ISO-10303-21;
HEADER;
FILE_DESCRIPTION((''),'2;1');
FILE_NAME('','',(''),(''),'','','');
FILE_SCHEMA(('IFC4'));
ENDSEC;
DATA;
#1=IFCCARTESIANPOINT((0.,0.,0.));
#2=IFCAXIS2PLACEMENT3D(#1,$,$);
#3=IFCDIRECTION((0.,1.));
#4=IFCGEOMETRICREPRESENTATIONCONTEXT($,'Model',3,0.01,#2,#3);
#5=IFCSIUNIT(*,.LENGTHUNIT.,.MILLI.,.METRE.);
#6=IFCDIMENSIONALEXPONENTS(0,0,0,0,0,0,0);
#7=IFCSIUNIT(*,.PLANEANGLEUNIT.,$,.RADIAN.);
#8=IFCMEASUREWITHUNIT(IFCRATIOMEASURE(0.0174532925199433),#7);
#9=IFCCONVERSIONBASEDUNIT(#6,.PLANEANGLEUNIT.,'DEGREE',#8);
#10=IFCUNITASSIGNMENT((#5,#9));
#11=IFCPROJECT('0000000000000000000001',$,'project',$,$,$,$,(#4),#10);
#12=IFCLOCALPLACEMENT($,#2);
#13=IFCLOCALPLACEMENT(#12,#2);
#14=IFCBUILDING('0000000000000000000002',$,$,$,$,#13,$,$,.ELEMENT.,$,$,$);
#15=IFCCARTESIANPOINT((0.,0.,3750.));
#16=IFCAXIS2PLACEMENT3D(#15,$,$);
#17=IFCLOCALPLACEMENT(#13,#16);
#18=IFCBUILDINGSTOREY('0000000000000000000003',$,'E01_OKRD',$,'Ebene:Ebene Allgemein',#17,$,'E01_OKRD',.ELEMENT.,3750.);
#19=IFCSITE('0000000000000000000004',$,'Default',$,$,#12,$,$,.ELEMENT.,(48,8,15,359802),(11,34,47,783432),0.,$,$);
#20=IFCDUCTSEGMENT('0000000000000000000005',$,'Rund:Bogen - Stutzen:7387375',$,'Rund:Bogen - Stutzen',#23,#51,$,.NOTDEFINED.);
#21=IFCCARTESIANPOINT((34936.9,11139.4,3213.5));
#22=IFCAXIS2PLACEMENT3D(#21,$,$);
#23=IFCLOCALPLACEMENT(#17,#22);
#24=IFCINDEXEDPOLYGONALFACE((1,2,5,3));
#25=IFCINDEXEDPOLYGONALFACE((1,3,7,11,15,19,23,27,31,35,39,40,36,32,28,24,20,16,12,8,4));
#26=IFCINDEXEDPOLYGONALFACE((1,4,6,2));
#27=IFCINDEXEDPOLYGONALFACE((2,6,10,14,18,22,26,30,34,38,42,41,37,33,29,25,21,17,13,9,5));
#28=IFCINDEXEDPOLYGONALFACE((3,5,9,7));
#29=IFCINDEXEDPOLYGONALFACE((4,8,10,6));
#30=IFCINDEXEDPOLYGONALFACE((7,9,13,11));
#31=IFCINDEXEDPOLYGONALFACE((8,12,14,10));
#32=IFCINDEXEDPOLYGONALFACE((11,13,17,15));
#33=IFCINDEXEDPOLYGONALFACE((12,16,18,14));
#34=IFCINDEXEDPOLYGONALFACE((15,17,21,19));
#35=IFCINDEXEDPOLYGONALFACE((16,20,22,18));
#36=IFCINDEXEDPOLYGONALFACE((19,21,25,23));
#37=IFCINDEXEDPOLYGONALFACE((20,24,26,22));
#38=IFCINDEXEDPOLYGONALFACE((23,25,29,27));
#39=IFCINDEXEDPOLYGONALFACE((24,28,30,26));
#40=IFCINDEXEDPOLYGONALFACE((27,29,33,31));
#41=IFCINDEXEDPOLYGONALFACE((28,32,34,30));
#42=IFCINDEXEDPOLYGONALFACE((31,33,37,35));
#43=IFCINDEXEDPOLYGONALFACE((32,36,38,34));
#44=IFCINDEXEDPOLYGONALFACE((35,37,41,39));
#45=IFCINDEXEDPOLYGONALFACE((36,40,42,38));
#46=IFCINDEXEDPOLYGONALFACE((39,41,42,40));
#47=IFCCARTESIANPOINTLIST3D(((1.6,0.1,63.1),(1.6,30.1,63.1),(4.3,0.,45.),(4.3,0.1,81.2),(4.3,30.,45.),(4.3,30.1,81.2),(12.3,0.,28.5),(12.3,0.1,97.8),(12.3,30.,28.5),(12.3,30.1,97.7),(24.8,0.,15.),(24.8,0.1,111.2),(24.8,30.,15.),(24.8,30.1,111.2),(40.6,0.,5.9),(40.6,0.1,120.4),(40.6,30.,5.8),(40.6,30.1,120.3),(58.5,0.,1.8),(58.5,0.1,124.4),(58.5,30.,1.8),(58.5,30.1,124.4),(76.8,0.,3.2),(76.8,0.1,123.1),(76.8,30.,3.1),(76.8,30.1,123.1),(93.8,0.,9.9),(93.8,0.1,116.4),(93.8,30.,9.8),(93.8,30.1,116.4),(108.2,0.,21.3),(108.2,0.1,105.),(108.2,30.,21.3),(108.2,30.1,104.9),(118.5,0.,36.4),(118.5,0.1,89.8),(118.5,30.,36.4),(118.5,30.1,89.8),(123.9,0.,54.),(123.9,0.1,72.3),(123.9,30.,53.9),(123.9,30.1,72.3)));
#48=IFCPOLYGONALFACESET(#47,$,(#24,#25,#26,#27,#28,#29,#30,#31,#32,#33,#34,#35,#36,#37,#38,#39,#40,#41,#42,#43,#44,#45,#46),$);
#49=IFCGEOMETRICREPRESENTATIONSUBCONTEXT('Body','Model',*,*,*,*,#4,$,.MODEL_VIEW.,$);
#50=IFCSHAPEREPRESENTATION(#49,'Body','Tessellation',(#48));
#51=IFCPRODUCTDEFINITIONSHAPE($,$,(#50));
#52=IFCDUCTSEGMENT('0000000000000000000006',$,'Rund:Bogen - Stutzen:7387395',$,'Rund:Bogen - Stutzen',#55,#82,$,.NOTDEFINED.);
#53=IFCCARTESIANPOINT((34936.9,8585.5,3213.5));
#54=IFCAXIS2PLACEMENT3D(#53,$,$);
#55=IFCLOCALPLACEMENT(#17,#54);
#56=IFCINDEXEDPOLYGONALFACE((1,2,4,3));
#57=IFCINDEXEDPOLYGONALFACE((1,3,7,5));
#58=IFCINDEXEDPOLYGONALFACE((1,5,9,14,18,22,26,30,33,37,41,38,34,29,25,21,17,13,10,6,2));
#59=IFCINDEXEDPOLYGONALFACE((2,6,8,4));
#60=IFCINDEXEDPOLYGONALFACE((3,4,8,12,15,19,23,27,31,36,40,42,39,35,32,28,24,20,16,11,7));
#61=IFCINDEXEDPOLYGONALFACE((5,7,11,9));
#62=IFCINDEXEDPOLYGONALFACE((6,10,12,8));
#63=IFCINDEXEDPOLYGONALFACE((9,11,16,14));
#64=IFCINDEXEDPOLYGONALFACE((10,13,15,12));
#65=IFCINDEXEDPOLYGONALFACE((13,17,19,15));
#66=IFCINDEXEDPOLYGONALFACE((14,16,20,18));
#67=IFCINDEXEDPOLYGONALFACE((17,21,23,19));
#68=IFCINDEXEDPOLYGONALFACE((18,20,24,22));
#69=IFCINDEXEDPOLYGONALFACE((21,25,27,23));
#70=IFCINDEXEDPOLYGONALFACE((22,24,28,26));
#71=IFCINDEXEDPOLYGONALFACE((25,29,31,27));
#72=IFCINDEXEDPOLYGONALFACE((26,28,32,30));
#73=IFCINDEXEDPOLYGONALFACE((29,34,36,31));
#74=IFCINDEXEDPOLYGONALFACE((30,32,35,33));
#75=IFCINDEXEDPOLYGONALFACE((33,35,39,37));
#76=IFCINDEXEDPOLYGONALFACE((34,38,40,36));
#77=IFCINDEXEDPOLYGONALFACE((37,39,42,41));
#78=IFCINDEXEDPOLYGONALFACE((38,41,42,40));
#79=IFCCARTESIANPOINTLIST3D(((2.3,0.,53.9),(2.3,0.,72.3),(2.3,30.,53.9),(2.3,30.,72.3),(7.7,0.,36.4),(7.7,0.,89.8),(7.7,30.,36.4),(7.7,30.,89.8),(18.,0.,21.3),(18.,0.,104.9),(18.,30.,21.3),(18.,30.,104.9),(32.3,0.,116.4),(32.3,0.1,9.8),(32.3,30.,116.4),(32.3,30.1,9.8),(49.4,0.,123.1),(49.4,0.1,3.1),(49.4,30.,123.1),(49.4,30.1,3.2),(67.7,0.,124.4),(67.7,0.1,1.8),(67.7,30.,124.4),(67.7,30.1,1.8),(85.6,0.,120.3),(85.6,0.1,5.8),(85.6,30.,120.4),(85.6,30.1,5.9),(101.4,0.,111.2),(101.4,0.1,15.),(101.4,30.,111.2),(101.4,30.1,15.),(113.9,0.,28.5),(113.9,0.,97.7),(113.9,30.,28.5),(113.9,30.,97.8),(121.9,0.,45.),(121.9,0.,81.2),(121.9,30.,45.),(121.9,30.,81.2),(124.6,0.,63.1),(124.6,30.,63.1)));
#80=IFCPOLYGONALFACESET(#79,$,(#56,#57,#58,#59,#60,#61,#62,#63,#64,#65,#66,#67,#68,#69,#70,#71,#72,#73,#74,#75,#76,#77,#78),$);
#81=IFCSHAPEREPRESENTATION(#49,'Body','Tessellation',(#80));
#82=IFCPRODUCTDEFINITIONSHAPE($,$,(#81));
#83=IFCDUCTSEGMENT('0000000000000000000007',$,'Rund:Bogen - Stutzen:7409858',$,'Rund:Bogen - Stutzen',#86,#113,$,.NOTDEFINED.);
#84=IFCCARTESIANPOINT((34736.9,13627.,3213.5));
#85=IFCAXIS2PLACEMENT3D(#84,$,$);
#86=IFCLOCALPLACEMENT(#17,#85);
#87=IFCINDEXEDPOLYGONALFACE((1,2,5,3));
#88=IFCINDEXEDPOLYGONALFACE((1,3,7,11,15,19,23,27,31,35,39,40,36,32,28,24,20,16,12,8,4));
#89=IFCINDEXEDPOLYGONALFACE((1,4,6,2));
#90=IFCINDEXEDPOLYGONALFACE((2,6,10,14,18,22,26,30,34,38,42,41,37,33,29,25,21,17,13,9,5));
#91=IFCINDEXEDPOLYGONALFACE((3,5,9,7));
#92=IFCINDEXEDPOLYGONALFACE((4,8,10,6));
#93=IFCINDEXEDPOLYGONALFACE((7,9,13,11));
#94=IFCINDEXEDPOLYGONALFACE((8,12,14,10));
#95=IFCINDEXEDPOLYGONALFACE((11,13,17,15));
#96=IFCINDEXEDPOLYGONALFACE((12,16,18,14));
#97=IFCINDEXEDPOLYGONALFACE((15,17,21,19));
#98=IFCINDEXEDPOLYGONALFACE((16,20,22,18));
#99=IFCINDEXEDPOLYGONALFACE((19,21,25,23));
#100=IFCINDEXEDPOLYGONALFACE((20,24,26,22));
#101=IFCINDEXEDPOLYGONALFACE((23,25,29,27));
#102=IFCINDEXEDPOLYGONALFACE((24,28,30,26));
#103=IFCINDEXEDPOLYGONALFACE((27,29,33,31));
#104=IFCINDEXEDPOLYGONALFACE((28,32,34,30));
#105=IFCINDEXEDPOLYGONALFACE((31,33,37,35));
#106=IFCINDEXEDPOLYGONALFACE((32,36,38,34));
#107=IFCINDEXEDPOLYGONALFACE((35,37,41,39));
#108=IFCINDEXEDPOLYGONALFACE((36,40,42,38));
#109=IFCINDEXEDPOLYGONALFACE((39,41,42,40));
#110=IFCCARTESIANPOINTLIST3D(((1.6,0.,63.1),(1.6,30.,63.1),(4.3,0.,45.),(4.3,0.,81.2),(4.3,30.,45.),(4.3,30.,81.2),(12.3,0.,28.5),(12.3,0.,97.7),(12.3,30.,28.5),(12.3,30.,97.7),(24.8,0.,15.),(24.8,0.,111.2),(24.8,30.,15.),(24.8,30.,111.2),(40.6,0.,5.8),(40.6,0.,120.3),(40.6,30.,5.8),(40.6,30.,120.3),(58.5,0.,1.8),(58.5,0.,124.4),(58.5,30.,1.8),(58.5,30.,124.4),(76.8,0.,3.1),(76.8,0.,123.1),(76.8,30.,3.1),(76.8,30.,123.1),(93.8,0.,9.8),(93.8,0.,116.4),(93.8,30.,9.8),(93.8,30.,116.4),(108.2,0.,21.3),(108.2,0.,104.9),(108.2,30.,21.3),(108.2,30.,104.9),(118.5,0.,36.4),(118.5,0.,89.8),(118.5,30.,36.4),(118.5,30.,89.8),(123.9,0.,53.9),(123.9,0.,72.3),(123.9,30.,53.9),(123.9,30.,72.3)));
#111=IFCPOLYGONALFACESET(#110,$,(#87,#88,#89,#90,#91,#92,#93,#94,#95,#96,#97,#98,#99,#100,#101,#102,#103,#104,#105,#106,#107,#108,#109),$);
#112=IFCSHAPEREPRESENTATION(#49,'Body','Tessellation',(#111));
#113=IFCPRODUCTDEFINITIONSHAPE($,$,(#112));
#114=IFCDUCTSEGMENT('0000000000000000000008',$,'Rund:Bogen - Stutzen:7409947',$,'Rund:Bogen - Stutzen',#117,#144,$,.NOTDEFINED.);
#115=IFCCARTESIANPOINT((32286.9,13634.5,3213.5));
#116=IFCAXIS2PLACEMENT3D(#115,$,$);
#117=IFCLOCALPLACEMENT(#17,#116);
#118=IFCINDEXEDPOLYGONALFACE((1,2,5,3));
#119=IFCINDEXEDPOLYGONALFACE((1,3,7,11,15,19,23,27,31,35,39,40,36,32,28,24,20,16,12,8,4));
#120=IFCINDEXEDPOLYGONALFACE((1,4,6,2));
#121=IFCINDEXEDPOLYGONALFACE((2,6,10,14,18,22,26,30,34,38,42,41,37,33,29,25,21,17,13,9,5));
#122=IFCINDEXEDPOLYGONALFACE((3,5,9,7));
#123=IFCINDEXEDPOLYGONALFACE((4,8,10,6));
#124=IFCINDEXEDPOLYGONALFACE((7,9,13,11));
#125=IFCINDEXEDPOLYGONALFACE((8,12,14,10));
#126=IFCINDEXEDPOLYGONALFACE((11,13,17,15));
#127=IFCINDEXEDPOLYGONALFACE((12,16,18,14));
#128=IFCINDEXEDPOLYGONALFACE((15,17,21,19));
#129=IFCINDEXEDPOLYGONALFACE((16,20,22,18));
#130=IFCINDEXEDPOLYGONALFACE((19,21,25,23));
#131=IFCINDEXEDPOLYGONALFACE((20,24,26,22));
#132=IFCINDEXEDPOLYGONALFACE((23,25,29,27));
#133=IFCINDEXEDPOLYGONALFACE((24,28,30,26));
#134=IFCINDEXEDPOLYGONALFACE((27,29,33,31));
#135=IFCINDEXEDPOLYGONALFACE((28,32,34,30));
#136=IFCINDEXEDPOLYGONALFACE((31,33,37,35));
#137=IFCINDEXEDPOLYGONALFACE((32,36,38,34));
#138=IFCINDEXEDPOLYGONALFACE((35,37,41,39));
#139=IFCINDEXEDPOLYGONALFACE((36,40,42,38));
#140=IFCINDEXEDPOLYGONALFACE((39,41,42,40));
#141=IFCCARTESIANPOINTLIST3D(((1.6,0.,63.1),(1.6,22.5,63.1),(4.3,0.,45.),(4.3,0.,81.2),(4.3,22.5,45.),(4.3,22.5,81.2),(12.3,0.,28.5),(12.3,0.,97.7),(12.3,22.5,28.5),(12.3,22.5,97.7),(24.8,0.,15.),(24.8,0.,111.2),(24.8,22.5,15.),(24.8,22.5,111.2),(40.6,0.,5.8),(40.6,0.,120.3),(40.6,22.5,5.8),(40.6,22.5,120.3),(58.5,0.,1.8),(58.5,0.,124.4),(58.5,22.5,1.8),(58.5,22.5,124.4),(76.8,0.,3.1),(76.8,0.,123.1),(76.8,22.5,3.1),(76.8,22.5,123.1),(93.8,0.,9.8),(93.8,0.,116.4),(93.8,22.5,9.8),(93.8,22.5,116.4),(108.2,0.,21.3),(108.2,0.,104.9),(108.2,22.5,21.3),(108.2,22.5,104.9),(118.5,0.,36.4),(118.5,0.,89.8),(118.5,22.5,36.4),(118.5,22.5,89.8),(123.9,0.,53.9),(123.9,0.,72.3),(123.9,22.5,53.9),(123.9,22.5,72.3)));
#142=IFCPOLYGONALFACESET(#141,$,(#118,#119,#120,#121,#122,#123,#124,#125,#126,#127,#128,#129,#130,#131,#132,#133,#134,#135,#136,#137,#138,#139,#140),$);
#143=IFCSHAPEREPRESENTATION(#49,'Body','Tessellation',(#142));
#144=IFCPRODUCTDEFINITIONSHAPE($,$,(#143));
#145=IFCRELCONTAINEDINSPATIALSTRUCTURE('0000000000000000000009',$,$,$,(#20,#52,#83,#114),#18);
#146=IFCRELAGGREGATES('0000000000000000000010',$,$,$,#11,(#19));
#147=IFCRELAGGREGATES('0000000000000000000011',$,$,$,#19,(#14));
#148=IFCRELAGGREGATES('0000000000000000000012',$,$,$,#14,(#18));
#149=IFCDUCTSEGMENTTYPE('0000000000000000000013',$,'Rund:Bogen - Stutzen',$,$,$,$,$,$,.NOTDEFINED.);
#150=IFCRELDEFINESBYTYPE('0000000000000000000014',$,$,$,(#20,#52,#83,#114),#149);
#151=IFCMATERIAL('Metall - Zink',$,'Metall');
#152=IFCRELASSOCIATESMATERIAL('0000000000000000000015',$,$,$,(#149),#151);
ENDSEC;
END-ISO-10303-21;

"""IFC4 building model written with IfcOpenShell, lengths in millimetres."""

from ifc_helpers import new_model, entity, si_unit, converted_unit, direction, frame, frame_2d, origin, place, context, subcontext, project, spatial, circle, extrude, material, type_object, element, save


model = new_model("IFC4")

# Units and contexts
model_context = context("Model", 3, precision=0.01, world=origin(), true_north=direction((0.0, 1.0)))
body_context = subcontext(model_context, "Body", "Model", "MODEL_VIEW")
ifc_project = project(units=[si_unit("LENGTHUNIT", "METRE", prefix="MILLI"), converted_unit("PLANEANGLEUNIT", "DEGREE", entity("IfcRatioMeasure", 0.0174532925199433), si_unit("PLANEANGLEUNIT", "RADIAN"), dimensions=[0, 0, 0, 0, 0, 0, 0])], contexts=[model_context])

# Site, building, storey
site_placement = place(None, origin())
site = spatial("IfcSite", under=ifc_project, at=site_placement, Name="Default", CompositionType="ELEMENT", RefLatitude=(48, 8, 15, 359802), RefLongitude=(11, 34, 47, 783432), RefElevation=0.0)
building_placement = place(site_placement, origin())
building = spatial("IfcBuilding", under=site, at=building_placement, CompositionType="ELEMENT")
storey_placement = place(building_placement, frame((0.0, 0.0, 3750.0)))
storey = spatial("IfcBuildingStorey", under=building, at=storey_placement, Name="E01_OKRD", ObjectType="Ebene:Ebene Allgemein", LongName="E01_OKRD", CompositionType="ELEMENT", Elevation=3750.0)

# Duct segments
ifc_material_1 = material(Name="Metall - Zink", Category="Metall")
duct_segment_type_1 = type_object("IfcDuctSegmentType", Name="Rund:Bogen - Stutzen", PredefinedType="NOTDEFINED", material=ifc_material_1)
duct_segment_1_placement = place(storey_placement, frame((34936.9, 11139.4, 3213.5)))
element("IfcDuctSegment", 1, at=duct_segment_1_placement, inside=storey, type_object=duct_segment_type_1, Name="Rund:Bogen - Stutzen:7387375", ObjectType="Rund:Bogen - Stutzen", PredefinedType="NOTDEFINED", context=body_context, shape_type="SweptSolid", body=[
    extrude(circle(Radius=61.5, at=frame_2d((0.0, 0.0), x_axis=(1.0, 0.0))), frame((63.1, 30.1, 63.1), z_axis=(0.0, -1.0, 0.000858), x_axis=(-1.0, 0.0, 0.0)), (0.0, 0.0, 1.0), 30.0),
])
duct_segment_2_placement = place(storey_placement, frame((34936.9, 8585.5, 3213.5)))
element("IfcDuctSegment", 2, at=duct_segment_2_placement, inside=storey, type_object=duct_segment_type_1, Name="Rund:Bogen - Stutzen:7387395", ObjectType="Rund:Bogen - Stutzen", PredefinedType="NOTDEFINED", context=body_context, shape_type="SweptSolid", body=[
    extrude(circle(Radius=61.5, at=frame_2d((0.0, 0.0), x_axis=(1.0, 0.0))), frame((63.1, 0.0, 63.1), z_axis=(0.0, 1.0, 0.000474), x_axis=(1.0, 0.0, 0.0)), (0.0, 0.0, 1.0), 30.0),
])
duct_segment_3_placement = place(storey_placement, frame((34736.9, 13627.0, 3213.5)))
element("IfcDuctSegment", 3, at=duct_segment_3_placement, inside=storey, type_object=duct_segment_type_1, Name="Rund:Bogen - Stutzen:7409858", ObjectType="Rund:Bogen - Stutzen", PredefinedType="NOTDEFINED", context=body_context, shape_type="SweptSolid", body=[
    extrude(circle(Radius=61.5, at=frame_2d((0.0, 0.0), x_axis=(1.0, 0.0))), frame((63.1, 0.0, 63.1), z_axis=(0.0, 1.0, 0.0), x_axis=(-1.0, 0.0, 0.0)), (0.0, 0.0, 1.0), 30.0),
])
duct_segment_4_placement = place(storey_placement, frame((32286.9, 13634.5, 3213.5)))
element("IfcDuctSegment", 4, at=duct_segment_4_placement, inside=storey, type_object=duct_segment_type_1, Name="Rund:Bogen - Stutzen:7409947", ObjectType="Rund:Bogen - Stutzen", PredefinedType="NOTDEFINED", context=body_context, shape_type="SweptSolid", body=[
    extrude(circle(Radius=61.5, at=frame_2d((0.0, 0.0), x_axis=(1.0, 0.0))), frame((63.1, 0.0, 63.1), z_axis=(0.0, 1.0, 0.0), x_axis=(-1.0, 0.0, 0.0)), (0.0, 0.0, 1.0), 22.5),
])

save(model, "model.ifc")
